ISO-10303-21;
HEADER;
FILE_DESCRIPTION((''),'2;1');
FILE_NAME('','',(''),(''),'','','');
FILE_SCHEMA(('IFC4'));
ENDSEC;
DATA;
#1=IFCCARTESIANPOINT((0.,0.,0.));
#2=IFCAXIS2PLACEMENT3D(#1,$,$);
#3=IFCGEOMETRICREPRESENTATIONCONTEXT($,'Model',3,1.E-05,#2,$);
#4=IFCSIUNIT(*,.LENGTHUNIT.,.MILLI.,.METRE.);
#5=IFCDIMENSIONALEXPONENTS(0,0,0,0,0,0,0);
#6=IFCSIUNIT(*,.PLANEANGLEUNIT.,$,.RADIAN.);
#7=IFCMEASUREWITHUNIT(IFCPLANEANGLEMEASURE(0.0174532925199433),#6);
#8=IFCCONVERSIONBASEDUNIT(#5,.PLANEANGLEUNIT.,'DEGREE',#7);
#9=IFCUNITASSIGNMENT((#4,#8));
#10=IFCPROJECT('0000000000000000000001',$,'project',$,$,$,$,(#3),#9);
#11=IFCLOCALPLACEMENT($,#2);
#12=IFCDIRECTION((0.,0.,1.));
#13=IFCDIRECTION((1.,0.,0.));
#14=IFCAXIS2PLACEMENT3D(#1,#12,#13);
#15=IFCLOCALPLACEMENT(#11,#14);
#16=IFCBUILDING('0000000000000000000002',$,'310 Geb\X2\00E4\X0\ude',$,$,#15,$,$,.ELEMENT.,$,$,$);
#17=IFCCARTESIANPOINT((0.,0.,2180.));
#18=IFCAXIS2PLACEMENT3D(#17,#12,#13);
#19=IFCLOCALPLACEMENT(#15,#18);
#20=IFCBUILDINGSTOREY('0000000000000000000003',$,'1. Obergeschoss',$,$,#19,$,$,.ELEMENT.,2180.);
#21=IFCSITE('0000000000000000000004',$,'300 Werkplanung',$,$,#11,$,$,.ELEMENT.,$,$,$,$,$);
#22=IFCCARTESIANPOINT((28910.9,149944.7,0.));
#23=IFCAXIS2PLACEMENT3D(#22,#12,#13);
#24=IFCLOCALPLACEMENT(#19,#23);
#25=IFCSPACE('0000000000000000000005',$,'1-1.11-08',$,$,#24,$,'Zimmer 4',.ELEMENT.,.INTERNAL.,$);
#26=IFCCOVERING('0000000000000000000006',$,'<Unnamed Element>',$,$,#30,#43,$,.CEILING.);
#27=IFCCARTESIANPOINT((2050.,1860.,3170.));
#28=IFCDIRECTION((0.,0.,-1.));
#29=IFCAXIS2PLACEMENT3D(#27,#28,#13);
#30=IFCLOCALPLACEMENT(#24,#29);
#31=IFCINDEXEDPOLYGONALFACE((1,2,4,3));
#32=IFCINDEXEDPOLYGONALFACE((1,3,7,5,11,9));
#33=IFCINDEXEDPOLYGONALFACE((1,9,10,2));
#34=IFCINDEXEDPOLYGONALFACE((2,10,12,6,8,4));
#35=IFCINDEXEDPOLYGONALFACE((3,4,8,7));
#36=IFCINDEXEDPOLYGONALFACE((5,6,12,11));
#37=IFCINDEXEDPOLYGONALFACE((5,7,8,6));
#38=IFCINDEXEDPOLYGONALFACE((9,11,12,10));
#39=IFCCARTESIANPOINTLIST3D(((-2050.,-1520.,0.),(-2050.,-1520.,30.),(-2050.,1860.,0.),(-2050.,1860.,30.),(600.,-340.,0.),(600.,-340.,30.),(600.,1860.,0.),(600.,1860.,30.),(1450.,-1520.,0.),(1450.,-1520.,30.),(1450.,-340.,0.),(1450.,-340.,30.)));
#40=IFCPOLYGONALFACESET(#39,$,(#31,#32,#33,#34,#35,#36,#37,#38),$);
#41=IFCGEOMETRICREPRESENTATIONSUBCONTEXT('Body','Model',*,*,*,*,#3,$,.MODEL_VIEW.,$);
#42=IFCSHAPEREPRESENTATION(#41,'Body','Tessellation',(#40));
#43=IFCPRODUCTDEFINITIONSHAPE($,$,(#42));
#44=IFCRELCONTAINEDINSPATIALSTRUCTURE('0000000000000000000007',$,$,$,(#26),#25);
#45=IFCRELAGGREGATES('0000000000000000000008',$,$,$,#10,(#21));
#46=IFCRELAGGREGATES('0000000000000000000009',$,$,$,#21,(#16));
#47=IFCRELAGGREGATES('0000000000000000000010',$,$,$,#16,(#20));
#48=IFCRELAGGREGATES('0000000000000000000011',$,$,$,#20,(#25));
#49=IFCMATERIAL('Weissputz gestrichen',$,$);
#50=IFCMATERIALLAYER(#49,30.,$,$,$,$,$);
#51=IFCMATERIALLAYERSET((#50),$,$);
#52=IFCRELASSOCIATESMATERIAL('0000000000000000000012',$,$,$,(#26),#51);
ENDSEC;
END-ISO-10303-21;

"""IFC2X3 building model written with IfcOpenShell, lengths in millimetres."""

from ifc_helpers import new_model, entity, si_unit, converted_unit, frame, origin, origin_with_axes, place, context, subcontext, project, spatial, polyline, outline, extrude, material, layer, layer_set, layer_usage, element, save


model = new_model("IFC2X3")

# Units and contexts
model_context = context("Model", 3, precision=1e-05, world=origin())
body_context = subcontext(model_context, "Body", "Model", "MODEL_VIEW")
ifc_project = project(units=[si_unit("LENGTHUNIT", "METRE", prefix="MILLI"), converted_unit("PLANEANGLEUNIT", "DEGREE", entity("IfcPlaneAngleMeasure", 0.0174532925199433), si_unit("PLANEANGLEUNIT", "RADIAN"), dimensions=[0, 0, 0, 0, 0, 0, 0])], contexts=[model_context])

# Site, building, storey
site_placement = place(None, origin())
site = spatial("IfcSite", under=ifc_project, at=site_placement, Name="300 Werkplanung", CompositionType="ELEMENT")
building_placement = place(site_placement, origin_with_axes())
building = spatial("IfcBuilding", under=site, at=building_placement, Name="310 Gebäude", CompositionType="ELEMENT")
storey_placement = place(building_placement, frame((0.0, 0.0, 2180.0), z_axis=(0.0, 0.0, 1.0), x_axis=(1.0, 0.0, 0.0)))
storey = spatial("IfcBuildingStorey", under=building, at=storey_placement, Name="1. Obergeschoss", CompositionType="ELEMENT", Elevation=2180.0)

# Shared definitions
space_1_placement = place(storey_placement, frame((28910.9, 149944.7, 0.0), z_axis=(0.0, 0.0, 1.0), x_axis=(1.0, 0.0, 0.0)))
space_1 = spatial("IfcSpace", under=storey, at=space_1_placement, Name="1-1.11-08", LongName="Zimmer 4", CompositionType="ELEMENT", InteriorOrExteriorSpace="INTERNAL")

# Covering
ifc_material_1 = material(Name="Weissputz gestrichen")
ifc_layer_1 = layer(ifc_material_1, 30.0)
ifc_layer_set_1 = layer_set([ifc_layer_1])
ifc_layer_usage_1 = layer_usage(ifc_layer_set_1, "AXIS3", "POSITIVE", 0.0)
covering_1_placement = place(space_1_placement, frame((2050.0, 1860.0, 3170.0), z_axis=(0.0, 0.0, -1.0), x_axis=(1.0, 0.0, 0.0)))
element("IfcCovering", 1, at=covering_1_placement, inside=space_1, material=ifc_layer_usage_1, Name="<Unnamed Element>", PredefinedType="CEILING", context=body_context, shape_type="SweptSolid", body=[
    extrude(outline(polyline([(-2050.0, -1520.0), (1450.0, -1520.0), (1450.0, -340.0), (600.0, -340.0), (600.0, 1860.0), (-2050.0, 1860.0), (-2050.0, -1520.0)])), origin_with_axes(), (0.0, 0.0, 1.0), 30.0),
])

save(model, "model.ifc")
